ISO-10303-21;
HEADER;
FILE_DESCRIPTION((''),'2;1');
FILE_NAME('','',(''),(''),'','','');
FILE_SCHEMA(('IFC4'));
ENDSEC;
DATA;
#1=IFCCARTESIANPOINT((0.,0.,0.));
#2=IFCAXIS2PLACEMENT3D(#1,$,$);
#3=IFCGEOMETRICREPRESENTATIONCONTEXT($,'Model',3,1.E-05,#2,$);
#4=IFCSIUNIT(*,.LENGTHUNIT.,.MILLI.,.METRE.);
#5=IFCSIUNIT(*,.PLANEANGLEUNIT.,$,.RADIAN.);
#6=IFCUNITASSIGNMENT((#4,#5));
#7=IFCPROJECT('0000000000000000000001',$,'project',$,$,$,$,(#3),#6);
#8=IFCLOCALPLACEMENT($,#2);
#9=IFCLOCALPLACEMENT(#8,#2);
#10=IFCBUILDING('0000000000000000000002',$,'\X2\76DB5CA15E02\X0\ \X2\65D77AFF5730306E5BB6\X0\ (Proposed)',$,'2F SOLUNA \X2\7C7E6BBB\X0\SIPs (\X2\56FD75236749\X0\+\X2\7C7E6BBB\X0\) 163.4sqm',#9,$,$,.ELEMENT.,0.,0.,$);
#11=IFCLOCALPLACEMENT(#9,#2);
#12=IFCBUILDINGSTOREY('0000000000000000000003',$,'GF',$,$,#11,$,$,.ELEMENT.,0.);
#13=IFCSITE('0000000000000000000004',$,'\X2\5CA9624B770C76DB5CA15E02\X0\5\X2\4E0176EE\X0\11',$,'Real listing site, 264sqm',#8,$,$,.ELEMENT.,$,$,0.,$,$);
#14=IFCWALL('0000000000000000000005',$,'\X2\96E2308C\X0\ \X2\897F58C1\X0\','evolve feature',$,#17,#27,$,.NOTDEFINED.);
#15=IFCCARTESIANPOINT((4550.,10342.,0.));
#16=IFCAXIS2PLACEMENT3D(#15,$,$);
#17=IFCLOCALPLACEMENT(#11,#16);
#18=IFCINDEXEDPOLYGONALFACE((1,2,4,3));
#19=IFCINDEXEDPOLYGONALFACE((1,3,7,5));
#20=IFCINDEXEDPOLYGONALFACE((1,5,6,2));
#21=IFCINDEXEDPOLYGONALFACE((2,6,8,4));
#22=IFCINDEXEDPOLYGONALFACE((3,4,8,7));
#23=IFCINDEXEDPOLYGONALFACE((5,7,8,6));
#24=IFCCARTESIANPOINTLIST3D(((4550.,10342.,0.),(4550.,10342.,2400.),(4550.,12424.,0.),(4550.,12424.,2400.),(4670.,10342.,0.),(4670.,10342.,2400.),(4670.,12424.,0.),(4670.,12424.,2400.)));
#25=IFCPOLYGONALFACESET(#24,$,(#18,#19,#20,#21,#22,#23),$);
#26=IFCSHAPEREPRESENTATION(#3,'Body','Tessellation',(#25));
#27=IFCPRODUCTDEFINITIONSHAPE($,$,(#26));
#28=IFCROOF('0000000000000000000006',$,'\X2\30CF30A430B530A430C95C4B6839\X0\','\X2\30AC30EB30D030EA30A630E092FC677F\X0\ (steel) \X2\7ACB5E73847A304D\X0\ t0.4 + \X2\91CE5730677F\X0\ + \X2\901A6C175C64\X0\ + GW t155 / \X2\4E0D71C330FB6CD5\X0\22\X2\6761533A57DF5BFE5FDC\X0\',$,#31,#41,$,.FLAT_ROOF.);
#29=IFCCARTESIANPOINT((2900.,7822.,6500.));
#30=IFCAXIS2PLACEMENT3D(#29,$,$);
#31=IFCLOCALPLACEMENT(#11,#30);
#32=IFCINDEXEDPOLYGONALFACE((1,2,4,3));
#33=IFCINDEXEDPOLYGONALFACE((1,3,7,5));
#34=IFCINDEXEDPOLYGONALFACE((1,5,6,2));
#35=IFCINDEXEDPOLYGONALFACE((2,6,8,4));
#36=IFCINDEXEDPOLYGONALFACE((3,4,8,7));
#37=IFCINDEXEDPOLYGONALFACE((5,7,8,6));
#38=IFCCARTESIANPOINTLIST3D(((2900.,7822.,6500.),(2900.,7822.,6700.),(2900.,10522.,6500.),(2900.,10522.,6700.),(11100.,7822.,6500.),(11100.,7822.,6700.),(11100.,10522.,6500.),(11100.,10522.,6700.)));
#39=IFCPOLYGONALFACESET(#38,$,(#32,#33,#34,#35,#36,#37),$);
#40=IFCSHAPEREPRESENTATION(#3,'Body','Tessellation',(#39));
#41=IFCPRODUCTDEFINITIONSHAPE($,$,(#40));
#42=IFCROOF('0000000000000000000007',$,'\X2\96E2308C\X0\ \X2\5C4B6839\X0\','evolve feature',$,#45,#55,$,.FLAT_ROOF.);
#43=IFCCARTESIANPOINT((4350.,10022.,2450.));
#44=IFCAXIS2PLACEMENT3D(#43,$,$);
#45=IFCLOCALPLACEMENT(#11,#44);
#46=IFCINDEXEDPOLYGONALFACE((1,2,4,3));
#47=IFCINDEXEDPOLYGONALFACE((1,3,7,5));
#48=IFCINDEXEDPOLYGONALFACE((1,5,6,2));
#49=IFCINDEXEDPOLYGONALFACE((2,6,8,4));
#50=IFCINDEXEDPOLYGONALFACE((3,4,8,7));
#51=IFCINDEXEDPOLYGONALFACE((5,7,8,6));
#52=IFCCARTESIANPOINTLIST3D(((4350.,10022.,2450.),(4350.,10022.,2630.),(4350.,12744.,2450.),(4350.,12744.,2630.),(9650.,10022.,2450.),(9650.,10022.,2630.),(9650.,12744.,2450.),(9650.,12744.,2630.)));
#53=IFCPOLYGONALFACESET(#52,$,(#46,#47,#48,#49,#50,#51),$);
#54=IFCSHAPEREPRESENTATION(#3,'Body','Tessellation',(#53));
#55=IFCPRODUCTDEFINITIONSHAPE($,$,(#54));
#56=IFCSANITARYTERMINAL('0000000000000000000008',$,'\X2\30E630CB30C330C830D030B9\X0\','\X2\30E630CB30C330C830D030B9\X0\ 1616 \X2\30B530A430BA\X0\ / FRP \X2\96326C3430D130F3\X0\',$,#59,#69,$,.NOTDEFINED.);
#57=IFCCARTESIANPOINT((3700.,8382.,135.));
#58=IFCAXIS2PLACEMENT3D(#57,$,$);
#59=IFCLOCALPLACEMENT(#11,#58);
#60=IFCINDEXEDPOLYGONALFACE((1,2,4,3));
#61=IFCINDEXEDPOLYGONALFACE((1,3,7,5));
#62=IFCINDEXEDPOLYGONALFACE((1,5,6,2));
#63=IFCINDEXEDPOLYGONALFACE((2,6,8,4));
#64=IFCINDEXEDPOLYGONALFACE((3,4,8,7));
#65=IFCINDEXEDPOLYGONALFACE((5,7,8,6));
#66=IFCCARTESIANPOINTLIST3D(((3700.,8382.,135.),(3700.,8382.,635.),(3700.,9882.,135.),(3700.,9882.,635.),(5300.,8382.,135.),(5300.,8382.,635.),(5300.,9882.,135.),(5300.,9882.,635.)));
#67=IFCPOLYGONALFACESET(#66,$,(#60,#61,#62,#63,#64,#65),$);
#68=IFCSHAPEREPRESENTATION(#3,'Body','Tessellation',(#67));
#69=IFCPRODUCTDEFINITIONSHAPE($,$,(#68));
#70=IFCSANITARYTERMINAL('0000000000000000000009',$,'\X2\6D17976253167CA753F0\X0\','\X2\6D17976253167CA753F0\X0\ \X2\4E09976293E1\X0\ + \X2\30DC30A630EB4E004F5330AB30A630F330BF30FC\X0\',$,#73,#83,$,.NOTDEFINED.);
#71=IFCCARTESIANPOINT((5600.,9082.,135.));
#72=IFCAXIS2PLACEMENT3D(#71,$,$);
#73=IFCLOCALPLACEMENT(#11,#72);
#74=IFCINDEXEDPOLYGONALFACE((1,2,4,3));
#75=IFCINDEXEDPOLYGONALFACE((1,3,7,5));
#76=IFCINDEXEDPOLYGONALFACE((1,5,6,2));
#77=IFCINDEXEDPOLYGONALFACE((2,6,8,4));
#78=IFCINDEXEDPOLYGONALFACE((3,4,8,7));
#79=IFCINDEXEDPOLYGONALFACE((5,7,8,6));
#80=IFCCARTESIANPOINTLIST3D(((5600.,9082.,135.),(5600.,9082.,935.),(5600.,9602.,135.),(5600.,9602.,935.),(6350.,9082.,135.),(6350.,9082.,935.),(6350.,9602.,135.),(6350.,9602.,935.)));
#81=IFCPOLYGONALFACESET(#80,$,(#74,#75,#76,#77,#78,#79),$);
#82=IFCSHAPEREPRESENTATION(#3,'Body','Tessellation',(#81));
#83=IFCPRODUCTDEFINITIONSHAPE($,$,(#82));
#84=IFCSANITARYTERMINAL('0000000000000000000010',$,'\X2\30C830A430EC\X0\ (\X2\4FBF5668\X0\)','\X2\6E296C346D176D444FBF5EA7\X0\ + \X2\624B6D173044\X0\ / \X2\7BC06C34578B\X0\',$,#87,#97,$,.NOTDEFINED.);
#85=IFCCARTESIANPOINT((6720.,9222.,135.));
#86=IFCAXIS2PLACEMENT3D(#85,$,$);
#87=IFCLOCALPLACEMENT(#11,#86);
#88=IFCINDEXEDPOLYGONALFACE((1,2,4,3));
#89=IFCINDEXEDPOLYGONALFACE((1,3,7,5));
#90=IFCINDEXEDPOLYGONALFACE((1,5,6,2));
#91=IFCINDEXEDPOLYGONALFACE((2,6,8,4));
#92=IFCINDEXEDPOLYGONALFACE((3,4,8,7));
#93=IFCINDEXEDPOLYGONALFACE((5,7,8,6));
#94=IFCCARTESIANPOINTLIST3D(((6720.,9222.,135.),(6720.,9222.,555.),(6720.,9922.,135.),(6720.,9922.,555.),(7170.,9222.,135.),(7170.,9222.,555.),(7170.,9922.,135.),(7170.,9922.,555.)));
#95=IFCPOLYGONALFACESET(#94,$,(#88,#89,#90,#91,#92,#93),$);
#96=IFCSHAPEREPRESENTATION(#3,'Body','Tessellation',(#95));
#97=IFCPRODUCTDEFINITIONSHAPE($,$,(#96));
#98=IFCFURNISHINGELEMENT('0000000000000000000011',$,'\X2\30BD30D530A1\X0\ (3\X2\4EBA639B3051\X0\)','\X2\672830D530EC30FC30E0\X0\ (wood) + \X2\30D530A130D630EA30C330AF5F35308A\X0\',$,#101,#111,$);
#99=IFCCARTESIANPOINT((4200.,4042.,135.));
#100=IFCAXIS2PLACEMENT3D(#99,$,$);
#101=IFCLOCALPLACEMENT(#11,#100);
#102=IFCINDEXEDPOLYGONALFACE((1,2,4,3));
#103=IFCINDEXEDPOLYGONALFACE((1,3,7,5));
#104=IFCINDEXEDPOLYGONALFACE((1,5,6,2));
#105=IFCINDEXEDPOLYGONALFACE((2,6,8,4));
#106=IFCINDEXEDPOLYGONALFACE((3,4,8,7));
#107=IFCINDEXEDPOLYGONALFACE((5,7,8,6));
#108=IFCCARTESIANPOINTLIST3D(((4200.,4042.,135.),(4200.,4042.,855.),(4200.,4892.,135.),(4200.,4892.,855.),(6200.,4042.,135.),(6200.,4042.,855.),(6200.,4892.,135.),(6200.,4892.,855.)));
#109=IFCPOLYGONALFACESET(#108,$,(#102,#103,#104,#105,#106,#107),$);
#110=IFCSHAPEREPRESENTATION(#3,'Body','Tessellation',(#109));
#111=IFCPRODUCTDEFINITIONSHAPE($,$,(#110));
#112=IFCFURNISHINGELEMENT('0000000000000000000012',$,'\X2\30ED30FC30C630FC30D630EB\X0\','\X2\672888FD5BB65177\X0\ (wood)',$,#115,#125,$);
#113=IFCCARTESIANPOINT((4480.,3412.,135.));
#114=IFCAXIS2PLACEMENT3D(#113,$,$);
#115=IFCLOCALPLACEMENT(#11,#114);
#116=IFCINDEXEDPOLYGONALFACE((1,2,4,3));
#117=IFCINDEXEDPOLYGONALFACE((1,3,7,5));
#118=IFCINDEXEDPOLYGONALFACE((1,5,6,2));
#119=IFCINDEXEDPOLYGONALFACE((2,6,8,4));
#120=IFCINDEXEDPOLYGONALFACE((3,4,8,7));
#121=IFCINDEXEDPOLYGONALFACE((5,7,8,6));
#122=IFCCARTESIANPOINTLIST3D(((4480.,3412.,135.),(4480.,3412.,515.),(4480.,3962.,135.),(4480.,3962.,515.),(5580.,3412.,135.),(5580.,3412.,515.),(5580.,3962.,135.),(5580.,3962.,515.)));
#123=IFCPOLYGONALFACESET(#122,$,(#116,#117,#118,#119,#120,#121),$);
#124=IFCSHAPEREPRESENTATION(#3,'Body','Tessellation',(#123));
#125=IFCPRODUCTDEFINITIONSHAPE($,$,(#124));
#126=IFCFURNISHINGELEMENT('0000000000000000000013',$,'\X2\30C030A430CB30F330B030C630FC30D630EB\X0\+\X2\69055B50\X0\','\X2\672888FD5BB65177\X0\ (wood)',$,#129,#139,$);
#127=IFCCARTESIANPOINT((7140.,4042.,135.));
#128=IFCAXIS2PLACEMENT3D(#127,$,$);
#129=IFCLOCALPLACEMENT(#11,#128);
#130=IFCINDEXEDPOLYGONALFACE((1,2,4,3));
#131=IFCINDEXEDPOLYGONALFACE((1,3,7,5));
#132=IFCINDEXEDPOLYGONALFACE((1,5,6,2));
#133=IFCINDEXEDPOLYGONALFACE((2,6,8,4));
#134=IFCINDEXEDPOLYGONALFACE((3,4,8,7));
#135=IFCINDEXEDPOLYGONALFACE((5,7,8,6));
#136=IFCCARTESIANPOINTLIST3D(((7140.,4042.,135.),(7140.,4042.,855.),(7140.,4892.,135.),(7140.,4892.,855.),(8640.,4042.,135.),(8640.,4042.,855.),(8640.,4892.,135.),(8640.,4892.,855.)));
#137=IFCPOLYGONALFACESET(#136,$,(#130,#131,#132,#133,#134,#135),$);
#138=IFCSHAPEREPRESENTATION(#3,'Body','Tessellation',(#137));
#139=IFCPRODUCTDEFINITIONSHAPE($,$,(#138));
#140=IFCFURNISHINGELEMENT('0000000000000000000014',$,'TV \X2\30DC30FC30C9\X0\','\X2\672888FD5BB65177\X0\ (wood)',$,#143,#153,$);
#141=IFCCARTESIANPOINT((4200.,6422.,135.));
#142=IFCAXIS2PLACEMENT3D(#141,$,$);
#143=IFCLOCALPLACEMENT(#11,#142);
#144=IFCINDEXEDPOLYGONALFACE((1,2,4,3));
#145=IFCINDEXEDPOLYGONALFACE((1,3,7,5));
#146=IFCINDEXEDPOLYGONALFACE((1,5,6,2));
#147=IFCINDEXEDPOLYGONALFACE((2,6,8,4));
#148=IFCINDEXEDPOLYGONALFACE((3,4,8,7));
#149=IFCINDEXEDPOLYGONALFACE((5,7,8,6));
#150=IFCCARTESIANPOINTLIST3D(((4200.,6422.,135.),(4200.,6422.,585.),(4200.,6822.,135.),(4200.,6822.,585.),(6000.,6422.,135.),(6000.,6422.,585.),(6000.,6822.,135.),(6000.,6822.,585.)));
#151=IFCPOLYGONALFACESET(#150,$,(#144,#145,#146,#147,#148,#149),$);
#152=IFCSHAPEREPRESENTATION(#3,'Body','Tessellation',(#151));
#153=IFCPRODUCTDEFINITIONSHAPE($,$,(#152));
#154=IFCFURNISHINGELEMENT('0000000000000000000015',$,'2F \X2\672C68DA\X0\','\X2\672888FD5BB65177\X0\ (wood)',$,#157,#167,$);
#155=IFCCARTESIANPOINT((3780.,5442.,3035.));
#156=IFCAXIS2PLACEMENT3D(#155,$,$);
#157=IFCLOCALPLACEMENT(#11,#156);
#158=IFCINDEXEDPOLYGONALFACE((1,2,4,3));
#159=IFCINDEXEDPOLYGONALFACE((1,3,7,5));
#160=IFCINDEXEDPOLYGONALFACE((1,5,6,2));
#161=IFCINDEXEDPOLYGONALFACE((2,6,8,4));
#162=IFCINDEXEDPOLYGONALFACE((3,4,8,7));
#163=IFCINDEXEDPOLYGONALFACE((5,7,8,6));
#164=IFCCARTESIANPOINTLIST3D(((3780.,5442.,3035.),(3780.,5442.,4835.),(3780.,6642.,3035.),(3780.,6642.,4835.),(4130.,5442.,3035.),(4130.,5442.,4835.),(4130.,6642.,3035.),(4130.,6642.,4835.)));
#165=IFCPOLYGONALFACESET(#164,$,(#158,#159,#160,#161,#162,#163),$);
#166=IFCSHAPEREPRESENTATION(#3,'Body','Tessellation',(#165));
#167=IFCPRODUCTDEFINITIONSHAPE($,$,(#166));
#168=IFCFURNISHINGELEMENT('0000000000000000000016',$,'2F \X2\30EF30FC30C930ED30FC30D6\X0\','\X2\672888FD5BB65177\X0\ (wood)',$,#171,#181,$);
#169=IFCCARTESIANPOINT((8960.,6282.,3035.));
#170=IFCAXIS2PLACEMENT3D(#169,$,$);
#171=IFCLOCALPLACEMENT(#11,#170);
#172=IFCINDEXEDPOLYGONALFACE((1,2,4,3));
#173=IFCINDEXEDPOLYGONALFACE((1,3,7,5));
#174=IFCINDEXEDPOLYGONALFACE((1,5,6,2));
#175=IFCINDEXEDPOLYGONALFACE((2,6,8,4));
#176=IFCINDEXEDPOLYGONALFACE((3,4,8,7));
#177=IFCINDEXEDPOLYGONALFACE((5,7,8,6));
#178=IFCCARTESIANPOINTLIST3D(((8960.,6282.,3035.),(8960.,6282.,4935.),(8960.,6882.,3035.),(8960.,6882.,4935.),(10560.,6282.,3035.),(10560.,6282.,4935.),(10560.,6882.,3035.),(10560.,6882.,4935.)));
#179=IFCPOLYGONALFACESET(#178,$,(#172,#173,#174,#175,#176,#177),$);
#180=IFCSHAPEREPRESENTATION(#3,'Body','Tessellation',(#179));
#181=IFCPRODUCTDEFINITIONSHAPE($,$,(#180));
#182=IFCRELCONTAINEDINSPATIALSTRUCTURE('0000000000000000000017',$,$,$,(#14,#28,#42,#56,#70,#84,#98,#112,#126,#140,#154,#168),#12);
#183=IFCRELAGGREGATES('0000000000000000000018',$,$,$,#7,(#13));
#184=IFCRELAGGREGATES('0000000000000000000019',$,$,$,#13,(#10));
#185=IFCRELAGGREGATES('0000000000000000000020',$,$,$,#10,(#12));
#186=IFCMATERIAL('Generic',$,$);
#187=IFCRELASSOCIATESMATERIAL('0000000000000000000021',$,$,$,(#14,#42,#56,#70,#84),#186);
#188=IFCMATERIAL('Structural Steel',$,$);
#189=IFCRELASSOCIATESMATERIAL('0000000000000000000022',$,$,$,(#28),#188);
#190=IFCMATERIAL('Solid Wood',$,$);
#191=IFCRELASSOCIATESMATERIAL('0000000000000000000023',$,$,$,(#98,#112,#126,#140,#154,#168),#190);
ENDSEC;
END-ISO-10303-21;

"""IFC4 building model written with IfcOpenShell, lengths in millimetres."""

from ifc_helpers import new_model, si_unit, frame, frame_2d, origin, place, context, project, spatial, rectangle, extrude, material, element, save


model = new_model("IFC4")

# Units and contexts
model_context = context("Model", 3, precision=1e-05, world=origin())
ifc_project = project(units=[si_unit("LENGTHUNIT", "METRE", prefix="MILLI"), si_unit("PLANEANGLEUNIT", "RADIAN")], contexts=[model_context])

# Site, building, storey
site_placement = place(None, origin())
site = spatial("IfcSite", under=ifc_project, at=site_placement, Name="岩手県盛岡市5丁目11", ObjectType="Real listing site, 264sqm", CompositionType="ELEMENT", RefElevation=0.0)
building_placement = place(site_placement, origin())
building = spatial("IfcBuilding", under=site, at=building_placement, Name="盛岡市 旗竿地の家 (Proposed)", ObjectType="2F SOLUNA 籾殻SIPs (国産杉+籾殻) 163.4sqm", CompositionType="ELEMENT", ElevationOfRefHeight=0.0, ElevationOfTerrain=0.0)
storey_placement = place(building_placement, origin())
storey = spatial("IfcBuildingStorey", under=building, at=storey_placement, Name="GF", CompositionType="ELEMENT", Elevation=0.0)

# Shared definitions
ifc_material_1 = material(Name="Generic")

# Shared definitions
ifc_material_2 = material(Name="Solid Wood")

# Wall
wall_1_placement = place(storey_placement, frame((4550.0, 10342.0, 0.0)))
element("IfcWall", 1, at=wall_1_placement, inside=storey, material=ifc_material_1, Name="離れ 西壁", Description="evolve feature", PredefinedType="NOTDEFINED", context=model_context, shape_type="SweptSolid", body=[
    extrude(rectangle(XDim=120.0, YDim=2082.0, at=frame_2d((60.0, 1041.0))), frame((4550.0, 10342.0, 0.0)), (0.0, 0.0, 1.0), 2400.0),
])

# Roofs
ifc_material_3 = material(Name="Structural Steel")
roof_1_placement = place(storey_placement, frame((2900.0, 7822.0, 6500.0)))
element("IfcRoof", 2, at=roof_1_placement, inside=storey, material=ifc_material_3, Name="ハイサイド屋根", Description="ガルバリウム鋼板 (steel) 立平葺き t0.4 + 野地板 + 通気層 + GW t155 / 不燃・法22条区域対応", PredefinedType="FLAT_ROOF", context=model_context, shape_type="SweptSolid", body=[
    extrude(rectangle(XDim=8200.0, YDim=2700.0, at=frame_2d((4100.0, 1350.0))), frame((2900.0, 7822.0, 6500.0)), (0.0, 0.0, 1.0), 200.0),
])
roof_2_placement = place(storey_placement, frame((4350.0, 10022.0, 2450.0)))
element("IfcRoof", 3, at=roof_2_placement, inside=storey, material=ifc_material_1, Name="離れ 屋根", Description="evolve feature", PredefinedType="FLAT_ROOF", context=model_context, shape_type="SweptSolid", body=[
    extrude(rectangle(XDim=5300.0, YDim=2722.0, at=frame_2d((2650.0, 1361.0))), frame((4350.0, 10022.0, 2450.0)), (0.0, 0.0, 1.0), 180.0),
])

# Sanitary terminals
sanitary_terminal_1_placement = place(storey_placement, frame((3700.0, 8382.0, 135.0)))
element("IfcSanitaryTerminal", 4, at=sanitary_terminal_1_placement, inside=storey, material=ifc_material_1, Name="ユニットバス", Description="ユニットバス 1616 サイズ / FRP 防水パン", PredefinedType="NOTDEFINED", context=model_context, shape_type="SweptSolid", body=[
    extrude(rectangle(XDim=1600.0, YDim=1500.0, at=frame_2d((800.0, 750.0))), frame((3700.0, 8382.0, 135.0)), (0.0, 0.0, 1.0), 500.0),
])
sanitary_terminal_2_placement = place(storey_placement, frame((5600.0, 9082.0, 135.0)))
element("IfcSanitaryTerminal", 5, at=sanitary_terminal_2_placement, inside=storey, material=ifc_material_1, Name="洗面化粧台", Description="洗面化粧台 三面鏡 + ボウル一体カウンター", PredefinedType="NOTDEFINED", context=model_context, shape_type="SweptSolid", body=[
    extrude(rectangle(XDim=750.0, YDim=520.0, at=frame_2d((375.0, 260.0))), frame((5600.0, 9082.0, 135.0)), (0.0, 0.0, 1.0), 800.0),
])
sanitary_terminal_3_placement = place(storey_placement, frame((6720.0, 9222.0, 135.0)))
element("IfcSanitaryTerminal", 6, at=sanitary_terminal_3_placement, inside=storey, material=ifc_material_1, Name="トイレ (便器)", Description="温水洗浄便座 + 手洗い / 節水型", PredefinedType="NOTDEFINED", context=model_context, shape_type="SweptSolid", body=[
    extrude(rectangle(XDim=450.0, YDim=700.0, at=frame_2d((225.0, 350.0))), frame((6720.0, 9222.0, 135.0)), (0.0, 0.0, 1.0), 420.0),
])

# Furnishing elements
furnishing_1_placement = place(storey_placement, frame((4200.0, 4042.0, 135.0)))
element("IfcFurnishingElement", 7, at=furnishing_1_placement, inside=storey, material=ifc_material_2, Name="ソファ (3人掛け)", Description="木フレーム (wood) + ファブリック張り", context=model_context, shape_type="SweptSolid", body=[
    extrude(rectangle(XDim=2000.0, YDim=850.0, at=frame_2d((1000.0, 425.0))), frame((4200.0, 4042.0, 135.0)), (0.0, 0.0, 1.0), 720.0),
])
furnishing_2_placement = place(storey_placement, frame((4480.0, 3412.0, 135.0)))
element("IfcFurnishingElement", 8, at=furnishing_2_placement, inside=storey, material=ifc_material_2, Name="ローテーブル", Description="木製家具 (wood)", context=model_context, shape_type="SweptSolid", body=[
    extrude(rectangle(XDim=1100.0, YDim=550.0, at=frame_2d((550.0, 275.0))), frame((4480.0, 3412.0, 135.0)), (0.0, 0.0, 1.0), 380.0),
])
furnishing_3_placement = place(storey_placement, frame((7140.0, 4042.0, 135.0)))
element("IfcFurnishingElement", 9, at=furnishing_3_placement, inside=storey, material=ifc_material_2, Name="ダイニングテーブル+椅子", Description="木製家具 (wood)", context=model_context, shape_type="SweptSolid", body=[
    extrude(rectangle(XDim=1500.0, YDim=850.0, at=frame_2d((750.0, 425.0))), frame((7140.0, 4042.0, 135.0)), (0.0, 0.0, 1.0), 720.0),
])
furnishing_4_placement = place(storey_placement, frame((4200.0, 6422.0, 135.0)))
element("IfcFurnishingElement", 10, at=furnishing_4_placement, inside=storey, material=ifc_material_2, Name="TV ボード", Description="木製家具 (wood)", context=model_context, shape_type="SweptSolid", body=[
    extrude(rectangle(XDim=1800.0, YDim=400.0, at=frame_2d((900.0, 200.0))), frame((4200.0, 6422.0, 135.0)), (0.0, 0.0, 1.0), 450.0),
])
furnishing_5_placement = place(storey_placement, frame((3780.0, 5442.0, 3035.0)))
element("IfcFurnishingElement", 11, at=furnishing_5_placement, inside=storey, material=ifc_material_2, Name="2F 本棚", Description="木製家具 (wood)", context=model_context, shape_type="SweptSolid", body=[
    extrude(rectangle(XDim=350.0, YDim=1200.0, at=frame_2d((175.0, 600.0))), frame((3780.0, 5442.0, 3035.0)), (0.0, 0.0, 1.0), 1800.0),
])
furnishing_6_placement = place(storey_placement, frame((8960.0, 6282.0, 3035.0)))
element("IfcFurnishingElement", 12, at=furnishing_6_placement, inside=storey, material=ifc_material_2, Name="2F ワードローブ", Description="木製家具 (wood)", context=model_context, shape_type="SweptSolid", body=[
    extrude(rectangle(XDim=1600.0, YDim=600.0, at=frame_2d((800.0, 300.0))), frame((8960.0, 6282.0, 3035.0)), (0.0, 0.0, 1.0), 1900.0),
])

save(model, "model.ifc")
